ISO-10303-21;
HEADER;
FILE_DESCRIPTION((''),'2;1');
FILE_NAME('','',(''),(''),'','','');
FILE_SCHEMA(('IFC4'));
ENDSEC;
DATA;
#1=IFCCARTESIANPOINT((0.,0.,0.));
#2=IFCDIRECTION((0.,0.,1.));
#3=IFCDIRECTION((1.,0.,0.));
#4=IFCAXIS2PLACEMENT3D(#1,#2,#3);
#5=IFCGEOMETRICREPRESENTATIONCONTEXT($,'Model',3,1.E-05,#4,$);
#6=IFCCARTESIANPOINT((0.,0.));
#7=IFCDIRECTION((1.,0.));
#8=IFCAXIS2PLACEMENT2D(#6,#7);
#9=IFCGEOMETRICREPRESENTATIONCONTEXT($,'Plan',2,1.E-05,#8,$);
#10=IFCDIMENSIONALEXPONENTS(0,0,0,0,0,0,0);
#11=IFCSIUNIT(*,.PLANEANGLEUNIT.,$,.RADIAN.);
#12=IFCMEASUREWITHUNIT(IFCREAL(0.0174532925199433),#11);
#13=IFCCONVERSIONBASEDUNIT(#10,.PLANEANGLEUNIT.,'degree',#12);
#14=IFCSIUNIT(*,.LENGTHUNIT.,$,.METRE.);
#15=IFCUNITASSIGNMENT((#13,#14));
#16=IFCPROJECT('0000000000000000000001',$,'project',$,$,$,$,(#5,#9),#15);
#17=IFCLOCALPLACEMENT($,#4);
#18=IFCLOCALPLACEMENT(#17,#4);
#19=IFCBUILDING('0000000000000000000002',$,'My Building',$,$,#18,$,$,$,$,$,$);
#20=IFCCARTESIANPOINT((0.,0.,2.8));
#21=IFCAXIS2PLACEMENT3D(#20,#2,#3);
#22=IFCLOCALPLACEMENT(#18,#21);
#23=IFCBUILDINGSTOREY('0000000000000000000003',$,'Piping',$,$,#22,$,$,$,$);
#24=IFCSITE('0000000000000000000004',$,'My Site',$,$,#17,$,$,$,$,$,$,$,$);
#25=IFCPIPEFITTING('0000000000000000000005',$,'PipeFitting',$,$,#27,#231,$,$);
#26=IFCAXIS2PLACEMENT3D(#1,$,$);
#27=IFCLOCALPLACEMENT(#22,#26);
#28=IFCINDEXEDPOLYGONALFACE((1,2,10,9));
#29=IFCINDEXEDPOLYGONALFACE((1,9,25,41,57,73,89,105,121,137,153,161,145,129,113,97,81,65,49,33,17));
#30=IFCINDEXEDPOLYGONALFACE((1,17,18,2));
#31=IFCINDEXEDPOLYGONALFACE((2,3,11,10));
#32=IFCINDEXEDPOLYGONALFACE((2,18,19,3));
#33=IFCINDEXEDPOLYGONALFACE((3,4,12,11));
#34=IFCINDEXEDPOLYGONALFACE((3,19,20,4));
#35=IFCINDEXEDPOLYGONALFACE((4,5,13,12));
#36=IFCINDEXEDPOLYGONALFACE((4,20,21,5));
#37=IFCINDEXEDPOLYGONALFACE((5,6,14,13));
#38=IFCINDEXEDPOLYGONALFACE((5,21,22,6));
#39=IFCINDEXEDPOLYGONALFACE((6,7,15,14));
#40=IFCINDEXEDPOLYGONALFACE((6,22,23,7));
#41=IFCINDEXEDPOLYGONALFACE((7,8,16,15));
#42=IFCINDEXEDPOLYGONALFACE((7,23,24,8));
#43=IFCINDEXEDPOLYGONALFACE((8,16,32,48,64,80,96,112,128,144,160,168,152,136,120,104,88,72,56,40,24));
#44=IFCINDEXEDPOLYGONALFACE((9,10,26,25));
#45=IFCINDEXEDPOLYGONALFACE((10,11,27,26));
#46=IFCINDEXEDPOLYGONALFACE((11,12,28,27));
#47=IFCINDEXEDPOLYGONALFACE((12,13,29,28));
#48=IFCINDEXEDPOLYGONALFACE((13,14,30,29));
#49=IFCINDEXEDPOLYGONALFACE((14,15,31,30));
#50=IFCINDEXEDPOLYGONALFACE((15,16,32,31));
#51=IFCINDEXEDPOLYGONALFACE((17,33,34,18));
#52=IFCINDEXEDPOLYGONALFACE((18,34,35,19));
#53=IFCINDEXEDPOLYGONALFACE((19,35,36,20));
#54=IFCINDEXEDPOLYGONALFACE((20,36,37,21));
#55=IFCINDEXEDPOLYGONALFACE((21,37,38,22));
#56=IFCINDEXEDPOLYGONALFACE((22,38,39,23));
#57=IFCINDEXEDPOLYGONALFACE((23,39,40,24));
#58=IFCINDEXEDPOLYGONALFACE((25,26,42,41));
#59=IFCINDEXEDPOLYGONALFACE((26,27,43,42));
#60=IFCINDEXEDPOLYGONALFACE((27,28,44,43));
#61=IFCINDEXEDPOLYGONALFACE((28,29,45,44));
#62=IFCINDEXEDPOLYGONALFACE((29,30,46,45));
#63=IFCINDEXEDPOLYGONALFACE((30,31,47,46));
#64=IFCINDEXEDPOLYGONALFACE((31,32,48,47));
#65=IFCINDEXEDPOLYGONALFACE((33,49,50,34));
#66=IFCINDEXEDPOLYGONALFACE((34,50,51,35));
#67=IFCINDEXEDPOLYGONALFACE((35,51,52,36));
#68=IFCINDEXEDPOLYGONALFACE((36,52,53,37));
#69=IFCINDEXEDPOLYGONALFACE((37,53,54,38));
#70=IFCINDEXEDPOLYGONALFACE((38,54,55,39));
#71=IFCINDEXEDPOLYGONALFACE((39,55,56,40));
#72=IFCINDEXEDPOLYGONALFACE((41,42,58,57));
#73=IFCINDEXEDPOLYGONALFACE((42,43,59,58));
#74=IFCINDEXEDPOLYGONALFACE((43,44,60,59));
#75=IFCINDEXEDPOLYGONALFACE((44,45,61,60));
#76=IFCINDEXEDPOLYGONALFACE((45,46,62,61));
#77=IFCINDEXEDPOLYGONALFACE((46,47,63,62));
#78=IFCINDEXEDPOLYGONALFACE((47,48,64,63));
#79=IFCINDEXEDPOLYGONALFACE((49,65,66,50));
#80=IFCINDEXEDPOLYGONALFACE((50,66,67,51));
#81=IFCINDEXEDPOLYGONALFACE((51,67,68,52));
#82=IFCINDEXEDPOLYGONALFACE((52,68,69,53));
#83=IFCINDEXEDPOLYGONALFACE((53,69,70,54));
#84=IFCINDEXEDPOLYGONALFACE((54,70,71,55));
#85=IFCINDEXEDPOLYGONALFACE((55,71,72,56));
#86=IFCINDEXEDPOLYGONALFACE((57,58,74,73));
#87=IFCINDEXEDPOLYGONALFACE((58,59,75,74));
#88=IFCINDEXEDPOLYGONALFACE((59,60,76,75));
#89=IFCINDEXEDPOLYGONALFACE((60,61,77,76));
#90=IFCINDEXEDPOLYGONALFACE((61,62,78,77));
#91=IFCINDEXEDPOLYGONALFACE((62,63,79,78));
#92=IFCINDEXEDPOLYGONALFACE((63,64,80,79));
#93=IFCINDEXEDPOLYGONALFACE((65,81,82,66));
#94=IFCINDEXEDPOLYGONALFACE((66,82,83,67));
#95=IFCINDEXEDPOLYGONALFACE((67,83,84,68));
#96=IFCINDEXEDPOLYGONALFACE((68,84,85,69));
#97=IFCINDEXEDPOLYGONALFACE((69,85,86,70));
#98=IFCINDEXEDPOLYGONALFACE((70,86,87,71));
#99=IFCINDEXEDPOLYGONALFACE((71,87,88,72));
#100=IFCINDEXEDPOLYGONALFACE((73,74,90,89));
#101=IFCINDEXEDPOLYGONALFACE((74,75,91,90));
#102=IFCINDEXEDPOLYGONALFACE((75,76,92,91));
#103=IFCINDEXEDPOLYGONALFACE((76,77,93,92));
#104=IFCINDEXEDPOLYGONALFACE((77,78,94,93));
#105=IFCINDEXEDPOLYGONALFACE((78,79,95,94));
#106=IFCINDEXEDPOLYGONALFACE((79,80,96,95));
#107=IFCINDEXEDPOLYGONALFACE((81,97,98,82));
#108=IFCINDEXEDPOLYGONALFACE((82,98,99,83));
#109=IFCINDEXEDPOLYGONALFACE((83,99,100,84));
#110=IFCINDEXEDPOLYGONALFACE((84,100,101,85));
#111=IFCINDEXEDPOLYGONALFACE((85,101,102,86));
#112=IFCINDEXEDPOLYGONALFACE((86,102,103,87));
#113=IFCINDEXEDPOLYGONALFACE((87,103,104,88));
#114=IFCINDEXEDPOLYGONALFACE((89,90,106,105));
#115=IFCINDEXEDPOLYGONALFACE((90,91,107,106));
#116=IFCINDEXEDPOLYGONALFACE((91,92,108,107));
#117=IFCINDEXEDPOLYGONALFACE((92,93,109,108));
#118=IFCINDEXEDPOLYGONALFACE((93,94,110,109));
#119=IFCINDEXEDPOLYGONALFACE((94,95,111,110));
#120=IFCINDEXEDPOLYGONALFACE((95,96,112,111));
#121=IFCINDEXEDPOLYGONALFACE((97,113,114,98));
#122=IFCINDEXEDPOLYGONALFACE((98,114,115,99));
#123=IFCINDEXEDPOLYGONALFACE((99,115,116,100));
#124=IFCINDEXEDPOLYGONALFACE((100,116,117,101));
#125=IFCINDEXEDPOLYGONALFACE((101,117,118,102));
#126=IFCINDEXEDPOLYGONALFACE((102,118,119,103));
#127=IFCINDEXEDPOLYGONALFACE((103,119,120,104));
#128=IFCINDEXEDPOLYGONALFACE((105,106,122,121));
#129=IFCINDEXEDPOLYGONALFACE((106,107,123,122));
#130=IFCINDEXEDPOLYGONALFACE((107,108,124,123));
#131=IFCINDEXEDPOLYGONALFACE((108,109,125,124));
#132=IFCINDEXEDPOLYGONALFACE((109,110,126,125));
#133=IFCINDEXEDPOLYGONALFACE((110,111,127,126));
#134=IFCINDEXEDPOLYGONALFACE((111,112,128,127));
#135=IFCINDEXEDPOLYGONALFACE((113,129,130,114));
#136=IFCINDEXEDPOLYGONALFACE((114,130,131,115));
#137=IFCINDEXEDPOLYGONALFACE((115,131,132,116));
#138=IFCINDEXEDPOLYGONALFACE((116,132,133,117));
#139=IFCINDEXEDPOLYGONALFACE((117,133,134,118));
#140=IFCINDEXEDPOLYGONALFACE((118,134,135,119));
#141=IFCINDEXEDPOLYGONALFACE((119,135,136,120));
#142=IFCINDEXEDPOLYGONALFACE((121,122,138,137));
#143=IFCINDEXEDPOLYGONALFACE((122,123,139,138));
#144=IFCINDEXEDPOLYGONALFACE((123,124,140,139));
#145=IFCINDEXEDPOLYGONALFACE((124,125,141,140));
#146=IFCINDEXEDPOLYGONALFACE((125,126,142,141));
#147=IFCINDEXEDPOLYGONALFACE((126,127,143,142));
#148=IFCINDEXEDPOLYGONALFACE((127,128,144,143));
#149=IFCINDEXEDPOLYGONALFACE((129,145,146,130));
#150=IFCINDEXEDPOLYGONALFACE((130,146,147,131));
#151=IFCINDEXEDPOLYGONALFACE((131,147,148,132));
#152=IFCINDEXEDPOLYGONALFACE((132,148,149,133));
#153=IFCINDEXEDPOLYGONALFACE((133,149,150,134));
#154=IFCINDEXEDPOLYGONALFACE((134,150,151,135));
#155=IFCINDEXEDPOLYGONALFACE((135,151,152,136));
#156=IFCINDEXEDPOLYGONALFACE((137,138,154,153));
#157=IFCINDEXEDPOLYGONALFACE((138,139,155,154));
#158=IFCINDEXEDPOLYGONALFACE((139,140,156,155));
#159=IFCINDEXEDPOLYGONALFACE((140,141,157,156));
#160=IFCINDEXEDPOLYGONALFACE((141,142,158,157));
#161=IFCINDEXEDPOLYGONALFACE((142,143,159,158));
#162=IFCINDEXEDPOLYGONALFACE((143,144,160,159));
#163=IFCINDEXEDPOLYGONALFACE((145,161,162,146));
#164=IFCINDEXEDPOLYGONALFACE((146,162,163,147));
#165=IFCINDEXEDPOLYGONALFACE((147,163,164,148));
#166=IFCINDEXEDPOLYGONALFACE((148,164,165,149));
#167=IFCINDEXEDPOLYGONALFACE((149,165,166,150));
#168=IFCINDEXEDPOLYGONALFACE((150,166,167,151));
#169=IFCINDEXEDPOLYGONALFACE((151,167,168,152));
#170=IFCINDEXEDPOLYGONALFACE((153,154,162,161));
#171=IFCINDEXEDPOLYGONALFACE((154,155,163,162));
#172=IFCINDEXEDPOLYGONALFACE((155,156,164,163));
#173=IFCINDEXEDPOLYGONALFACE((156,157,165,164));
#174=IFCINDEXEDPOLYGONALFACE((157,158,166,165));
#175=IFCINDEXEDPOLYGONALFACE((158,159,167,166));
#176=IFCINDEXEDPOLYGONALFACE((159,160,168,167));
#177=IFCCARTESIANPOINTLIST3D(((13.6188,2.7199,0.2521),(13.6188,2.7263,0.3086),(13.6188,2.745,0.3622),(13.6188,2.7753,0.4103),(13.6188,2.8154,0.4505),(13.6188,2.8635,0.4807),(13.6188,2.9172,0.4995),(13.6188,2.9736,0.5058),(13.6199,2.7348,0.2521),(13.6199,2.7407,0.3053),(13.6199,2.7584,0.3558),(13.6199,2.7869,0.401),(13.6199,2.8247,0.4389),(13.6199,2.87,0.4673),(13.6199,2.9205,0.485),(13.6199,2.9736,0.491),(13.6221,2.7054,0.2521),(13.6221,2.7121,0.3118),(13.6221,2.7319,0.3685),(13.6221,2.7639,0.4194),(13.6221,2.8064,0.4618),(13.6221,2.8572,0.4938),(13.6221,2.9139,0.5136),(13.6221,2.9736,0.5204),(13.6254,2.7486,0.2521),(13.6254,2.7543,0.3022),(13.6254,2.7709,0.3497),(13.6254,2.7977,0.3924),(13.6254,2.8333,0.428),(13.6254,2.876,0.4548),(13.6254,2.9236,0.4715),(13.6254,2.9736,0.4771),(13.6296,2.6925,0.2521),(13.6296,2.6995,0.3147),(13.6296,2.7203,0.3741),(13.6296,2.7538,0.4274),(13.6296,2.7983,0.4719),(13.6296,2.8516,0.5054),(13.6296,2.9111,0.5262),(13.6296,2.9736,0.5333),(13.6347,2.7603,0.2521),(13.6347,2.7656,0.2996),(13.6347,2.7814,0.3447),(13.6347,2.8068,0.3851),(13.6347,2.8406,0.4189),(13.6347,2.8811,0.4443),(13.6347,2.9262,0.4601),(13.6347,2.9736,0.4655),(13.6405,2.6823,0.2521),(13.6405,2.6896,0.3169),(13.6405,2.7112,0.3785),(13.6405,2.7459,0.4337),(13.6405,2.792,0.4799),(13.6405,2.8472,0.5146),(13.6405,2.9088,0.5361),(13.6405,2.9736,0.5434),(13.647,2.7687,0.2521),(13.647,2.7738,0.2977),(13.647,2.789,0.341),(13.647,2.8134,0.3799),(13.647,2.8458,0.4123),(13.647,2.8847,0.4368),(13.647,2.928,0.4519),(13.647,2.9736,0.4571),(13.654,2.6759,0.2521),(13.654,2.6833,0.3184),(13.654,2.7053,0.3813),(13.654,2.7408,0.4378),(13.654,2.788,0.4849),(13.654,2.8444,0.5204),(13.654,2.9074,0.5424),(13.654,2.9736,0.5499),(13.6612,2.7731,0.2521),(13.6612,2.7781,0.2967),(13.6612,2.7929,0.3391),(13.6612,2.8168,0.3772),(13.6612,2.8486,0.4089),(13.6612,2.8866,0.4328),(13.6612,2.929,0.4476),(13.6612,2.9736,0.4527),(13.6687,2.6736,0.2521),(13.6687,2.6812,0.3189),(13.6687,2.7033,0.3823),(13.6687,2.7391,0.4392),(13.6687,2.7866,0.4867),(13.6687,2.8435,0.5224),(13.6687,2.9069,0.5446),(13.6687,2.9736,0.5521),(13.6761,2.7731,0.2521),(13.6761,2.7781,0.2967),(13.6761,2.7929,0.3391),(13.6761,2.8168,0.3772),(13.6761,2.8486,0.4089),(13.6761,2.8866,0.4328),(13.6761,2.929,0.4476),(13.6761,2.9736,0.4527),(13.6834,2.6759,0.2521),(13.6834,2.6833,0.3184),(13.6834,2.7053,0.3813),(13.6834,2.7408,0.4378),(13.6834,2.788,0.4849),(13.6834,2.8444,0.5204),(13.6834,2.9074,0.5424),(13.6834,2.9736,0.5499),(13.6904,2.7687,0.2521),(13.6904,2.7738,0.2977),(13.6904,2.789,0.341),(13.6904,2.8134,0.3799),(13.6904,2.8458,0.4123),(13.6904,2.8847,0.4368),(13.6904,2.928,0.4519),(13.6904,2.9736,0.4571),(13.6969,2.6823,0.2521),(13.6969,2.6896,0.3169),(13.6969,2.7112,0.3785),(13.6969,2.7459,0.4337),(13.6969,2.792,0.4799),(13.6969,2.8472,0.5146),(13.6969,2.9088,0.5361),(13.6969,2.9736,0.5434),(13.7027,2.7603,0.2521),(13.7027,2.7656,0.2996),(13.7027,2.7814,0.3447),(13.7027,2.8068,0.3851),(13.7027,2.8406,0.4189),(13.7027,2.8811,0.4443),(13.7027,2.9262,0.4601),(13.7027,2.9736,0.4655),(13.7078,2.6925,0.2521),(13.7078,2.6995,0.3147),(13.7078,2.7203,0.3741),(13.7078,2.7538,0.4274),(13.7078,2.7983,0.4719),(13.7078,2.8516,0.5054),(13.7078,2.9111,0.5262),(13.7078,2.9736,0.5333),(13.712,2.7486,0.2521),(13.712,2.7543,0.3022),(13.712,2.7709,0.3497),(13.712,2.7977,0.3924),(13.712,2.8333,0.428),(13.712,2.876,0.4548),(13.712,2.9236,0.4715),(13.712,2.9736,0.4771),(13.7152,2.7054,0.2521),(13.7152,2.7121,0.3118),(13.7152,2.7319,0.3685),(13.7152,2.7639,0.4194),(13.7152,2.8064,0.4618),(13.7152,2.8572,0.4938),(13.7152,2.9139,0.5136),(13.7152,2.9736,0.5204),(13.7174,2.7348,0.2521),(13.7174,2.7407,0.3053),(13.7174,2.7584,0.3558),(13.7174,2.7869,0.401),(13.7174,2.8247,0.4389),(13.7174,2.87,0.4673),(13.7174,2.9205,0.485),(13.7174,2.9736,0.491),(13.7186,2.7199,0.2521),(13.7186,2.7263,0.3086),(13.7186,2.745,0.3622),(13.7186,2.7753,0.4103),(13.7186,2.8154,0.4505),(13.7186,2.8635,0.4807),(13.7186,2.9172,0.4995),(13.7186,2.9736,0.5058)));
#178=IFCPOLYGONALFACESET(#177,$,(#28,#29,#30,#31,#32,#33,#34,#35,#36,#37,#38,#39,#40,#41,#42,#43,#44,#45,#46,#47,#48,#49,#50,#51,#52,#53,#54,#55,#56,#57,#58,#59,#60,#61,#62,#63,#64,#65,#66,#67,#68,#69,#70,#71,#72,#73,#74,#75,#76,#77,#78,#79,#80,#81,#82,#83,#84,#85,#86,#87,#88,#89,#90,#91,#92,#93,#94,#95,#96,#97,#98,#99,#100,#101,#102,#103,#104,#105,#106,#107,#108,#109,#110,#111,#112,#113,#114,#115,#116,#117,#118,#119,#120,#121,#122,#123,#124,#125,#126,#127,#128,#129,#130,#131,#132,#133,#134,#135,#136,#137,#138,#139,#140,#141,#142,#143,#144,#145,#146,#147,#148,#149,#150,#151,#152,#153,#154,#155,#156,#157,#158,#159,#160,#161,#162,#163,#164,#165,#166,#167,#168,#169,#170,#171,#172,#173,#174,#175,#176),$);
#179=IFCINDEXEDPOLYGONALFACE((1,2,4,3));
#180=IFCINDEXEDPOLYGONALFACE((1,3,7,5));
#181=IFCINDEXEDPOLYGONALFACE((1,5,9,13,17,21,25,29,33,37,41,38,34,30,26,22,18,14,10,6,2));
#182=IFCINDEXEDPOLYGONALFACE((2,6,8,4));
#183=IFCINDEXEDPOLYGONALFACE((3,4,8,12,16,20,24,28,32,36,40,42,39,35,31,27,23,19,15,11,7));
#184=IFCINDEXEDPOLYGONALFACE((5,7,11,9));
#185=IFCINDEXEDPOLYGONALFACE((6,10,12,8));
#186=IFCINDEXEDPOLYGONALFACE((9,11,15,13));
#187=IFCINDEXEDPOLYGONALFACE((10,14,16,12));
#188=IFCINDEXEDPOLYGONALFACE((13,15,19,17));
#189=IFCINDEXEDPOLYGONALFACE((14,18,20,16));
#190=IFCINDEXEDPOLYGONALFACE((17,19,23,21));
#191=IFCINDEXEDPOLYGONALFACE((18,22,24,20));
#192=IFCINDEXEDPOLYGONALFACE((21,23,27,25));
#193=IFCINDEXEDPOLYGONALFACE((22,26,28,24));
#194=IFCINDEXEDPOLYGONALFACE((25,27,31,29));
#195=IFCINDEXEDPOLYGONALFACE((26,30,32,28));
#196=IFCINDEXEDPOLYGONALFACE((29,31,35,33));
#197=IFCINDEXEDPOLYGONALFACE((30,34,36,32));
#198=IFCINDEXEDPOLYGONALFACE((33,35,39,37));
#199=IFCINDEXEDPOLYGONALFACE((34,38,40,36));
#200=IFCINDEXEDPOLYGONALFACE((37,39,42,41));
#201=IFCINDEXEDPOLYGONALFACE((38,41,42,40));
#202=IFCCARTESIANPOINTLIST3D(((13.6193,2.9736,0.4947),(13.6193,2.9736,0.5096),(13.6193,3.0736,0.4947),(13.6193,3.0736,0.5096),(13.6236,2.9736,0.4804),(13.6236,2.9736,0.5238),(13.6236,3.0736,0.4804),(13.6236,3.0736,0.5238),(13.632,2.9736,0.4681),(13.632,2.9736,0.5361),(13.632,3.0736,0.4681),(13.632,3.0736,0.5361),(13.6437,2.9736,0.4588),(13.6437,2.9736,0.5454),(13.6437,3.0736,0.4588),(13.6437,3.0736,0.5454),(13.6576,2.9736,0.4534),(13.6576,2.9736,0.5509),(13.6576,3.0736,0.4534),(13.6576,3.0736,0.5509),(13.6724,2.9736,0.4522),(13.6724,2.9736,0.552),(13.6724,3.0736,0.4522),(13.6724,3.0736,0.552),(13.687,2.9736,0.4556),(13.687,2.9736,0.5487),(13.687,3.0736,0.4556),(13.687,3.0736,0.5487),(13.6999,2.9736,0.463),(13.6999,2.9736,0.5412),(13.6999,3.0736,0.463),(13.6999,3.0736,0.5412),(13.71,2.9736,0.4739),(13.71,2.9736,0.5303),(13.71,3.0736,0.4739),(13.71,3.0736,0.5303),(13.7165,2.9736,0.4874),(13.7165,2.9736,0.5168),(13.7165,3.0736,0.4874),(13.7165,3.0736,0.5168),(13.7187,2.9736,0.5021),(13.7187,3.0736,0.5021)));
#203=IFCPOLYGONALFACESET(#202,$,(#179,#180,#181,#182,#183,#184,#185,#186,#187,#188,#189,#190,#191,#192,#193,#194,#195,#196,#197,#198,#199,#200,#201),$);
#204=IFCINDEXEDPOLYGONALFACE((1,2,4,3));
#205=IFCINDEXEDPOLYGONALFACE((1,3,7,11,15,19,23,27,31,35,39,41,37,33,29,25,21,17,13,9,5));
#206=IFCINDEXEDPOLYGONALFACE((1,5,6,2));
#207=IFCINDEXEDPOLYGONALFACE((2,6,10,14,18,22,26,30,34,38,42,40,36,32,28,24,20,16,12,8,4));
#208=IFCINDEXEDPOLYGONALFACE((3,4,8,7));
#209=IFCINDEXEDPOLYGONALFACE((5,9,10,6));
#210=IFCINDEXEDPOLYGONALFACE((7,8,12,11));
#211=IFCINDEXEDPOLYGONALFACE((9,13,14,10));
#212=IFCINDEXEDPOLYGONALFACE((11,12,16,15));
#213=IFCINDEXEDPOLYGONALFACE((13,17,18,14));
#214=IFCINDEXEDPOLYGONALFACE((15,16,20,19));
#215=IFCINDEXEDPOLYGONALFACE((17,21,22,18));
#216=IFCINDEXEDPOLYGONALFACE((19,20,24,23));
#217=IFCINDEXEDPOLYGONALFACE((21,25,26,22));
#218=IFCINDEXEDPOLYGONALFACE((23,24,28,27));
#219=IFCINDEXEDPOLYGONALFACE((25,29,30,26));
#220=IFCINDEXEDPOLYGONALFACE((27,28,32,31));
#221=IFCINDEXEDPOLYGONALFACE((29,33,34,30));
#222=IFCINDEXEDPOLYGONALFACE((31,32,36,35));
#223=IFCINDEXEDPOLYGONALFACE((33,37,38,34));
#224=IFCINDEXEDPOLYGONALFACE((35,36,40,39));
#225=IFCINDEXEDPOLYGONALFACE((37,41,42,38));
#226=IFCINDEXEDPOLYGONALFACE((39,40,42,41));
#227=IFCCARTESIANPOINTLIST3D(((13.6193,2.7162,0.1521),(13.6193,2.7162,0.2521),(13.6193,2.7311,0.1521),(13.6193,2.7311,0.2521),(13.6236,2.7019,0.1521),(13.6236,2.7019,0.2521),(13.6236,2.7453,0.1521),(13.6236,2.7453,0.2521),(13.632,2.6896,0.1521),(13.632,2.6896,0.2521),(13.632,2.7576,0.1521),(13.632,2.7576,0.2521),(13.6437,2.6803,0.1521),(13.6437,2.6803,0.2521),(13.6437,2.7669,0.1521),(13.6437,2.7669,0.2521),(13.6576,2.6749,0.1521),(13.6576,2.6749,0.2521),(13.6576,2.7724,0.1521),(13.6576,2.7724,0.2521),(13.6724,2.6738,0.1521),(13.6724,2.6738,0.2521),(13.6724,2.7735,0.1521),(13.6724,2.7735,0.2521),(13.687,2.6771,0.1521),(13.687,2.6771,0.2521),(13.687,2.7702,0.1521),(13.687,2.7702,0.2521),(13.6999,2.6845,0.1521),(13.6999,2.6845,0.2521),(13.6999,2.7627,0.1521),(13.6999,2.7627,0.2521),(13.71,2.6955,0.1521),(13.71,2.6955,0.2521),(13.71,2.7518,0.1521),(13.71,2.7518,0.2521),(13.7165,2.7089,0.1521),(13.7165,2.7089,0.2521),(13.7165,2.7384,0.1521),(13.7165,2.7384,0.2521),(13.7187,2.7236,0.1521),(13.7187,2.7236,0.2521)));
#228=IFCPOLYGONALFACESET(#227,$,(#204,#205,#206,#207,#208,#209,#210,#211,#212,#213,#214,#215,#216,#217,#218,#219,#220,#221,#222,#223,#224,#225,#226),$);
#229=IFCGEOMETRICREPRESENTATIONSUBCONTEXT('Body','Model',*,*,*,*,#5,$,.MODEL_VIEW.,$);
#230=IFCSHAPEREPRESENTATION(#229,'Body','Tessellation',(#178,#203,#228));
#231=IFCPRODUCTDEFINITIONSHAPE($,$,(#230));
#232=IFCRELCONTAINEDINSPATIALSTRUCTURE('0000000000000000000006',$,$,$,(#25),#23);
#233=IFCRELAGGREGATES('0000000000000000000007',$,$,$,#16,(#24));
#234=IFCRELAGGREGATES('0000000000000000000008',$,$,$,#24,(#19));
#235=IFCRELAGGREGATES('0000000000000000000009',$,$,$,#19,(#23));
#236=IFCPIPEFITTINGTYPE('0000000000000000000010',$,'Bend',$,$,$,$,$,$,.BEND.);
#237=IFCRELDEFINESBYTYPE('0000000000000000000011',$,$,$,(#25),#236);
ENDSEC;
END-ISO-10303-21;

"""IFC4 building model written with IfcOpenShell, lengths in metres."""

from ifc_helpers import new_model, entity, si_unit, converted_unit, frame, origin_with_axes, origin_2d_with_axis, place, context, subcontext, project, spatial, circle, extrude, source, transform, mapped, type_object, type_shapes, element, save


model = new_model("IFC4")

# Units and contexts
model_context = context("Model", 3, precision=1e-05, world=origin_with_axes())
plan_context = context("Plan", 2, precision=1e-05, world=origin_2d_with_axis())
body_context = subcontext(model_context, "Body", "Model", "MODEL_VIEW")
ifc_project = project(units=[converted_unit("PLANEANGLEUNIT", "degree", entity("IfcReal", 0.0174532925199433), si_unit("PLANEANGLEUNIT", "RADIAN"), dimensions=[0, 0, 0, 0, 0, 0, 0]), si_unit("LENGTHUNIT", "METRE")], contexts=[model_context, plan_context])

# Site, building, storey
site_placement = place(None, origin_with_axes())
site = spatial("IfcSite", under=ifc_project, at=site_placement, Name="My Site")
building_placement = place(site_placement, origin_with_axes())
building = spatial("IfcBuilding", under=site, at=building_placement, Name="My Building")
storey_placement = place(building_placement, frame((0.0, 0.0, 2.8), z_axis=(0.0, 0.0, 1.0), x_axis=(1.0, 0.0, 0.0)))
storey = spatial("IfcBuildingStorey", under=building, at=storey_placement, Name="Piping")

# Pipe fitting
pipe_fitting_type_1 = type_object("IfcPipeFittingType", Name="Bend", PredefinedType="BEND")
shared_shape_1 = source(origin_with_axes(), body_context, "Body", "SolidModel", [
    entity("IfcSweptDiskSolid", entity("IfcIndexedPolyCurve", entity("IfcCartesianPointList3D", [[0.0, 0.0, 0.1], [0.0, -0.0732, 0.2768], [0.0, -0.25, 0.35]]), [entity("IfcArcIndex", [1, 2, 3])]), 0.05),
    extrude(circle(Radius=0.05), origin_with_axes(), (0.0, 0.0, 1.0), 0.1),
    extrude(circle(Radius=0.05), frame((0.0, -0.25, 0.35), z_axis=(0.0, -1.0, 0.0), x_axis=(1.0, 0.0, 0.0)), (0.0, 0.0, 1.0), 0.1),
])
type_shapes(pipe_fitting_type_1, [shared_shape_1])
for number, where, z_axis, x_axis, name in (
    (1, (13.6687, 3.0736, 0.5021), (0.0, -1.0, 0.0), (1.0, 0.0, 0.0), "PipeFitting"),
):
    element("IfcPipeFitting", number, at=place(storey_placement, frame(where, z_axis=z_axis, x_axis=x_axis)), inside=storey, type_object=pipe_fitting_type_1, Name=name, context=body_context, shape_type="MappedRepresentation", body=[
        mapped(shared_shape_1, transform((0.0, 0.0, 0.0), x_axis=(1.0, 0.0, 0.0), y_axis=(0.0, 1.0, 0.0), z_axis=(0.0, 0.0, 1.0), scale=1.0)),
    ])

save(model, "model.ifc")
